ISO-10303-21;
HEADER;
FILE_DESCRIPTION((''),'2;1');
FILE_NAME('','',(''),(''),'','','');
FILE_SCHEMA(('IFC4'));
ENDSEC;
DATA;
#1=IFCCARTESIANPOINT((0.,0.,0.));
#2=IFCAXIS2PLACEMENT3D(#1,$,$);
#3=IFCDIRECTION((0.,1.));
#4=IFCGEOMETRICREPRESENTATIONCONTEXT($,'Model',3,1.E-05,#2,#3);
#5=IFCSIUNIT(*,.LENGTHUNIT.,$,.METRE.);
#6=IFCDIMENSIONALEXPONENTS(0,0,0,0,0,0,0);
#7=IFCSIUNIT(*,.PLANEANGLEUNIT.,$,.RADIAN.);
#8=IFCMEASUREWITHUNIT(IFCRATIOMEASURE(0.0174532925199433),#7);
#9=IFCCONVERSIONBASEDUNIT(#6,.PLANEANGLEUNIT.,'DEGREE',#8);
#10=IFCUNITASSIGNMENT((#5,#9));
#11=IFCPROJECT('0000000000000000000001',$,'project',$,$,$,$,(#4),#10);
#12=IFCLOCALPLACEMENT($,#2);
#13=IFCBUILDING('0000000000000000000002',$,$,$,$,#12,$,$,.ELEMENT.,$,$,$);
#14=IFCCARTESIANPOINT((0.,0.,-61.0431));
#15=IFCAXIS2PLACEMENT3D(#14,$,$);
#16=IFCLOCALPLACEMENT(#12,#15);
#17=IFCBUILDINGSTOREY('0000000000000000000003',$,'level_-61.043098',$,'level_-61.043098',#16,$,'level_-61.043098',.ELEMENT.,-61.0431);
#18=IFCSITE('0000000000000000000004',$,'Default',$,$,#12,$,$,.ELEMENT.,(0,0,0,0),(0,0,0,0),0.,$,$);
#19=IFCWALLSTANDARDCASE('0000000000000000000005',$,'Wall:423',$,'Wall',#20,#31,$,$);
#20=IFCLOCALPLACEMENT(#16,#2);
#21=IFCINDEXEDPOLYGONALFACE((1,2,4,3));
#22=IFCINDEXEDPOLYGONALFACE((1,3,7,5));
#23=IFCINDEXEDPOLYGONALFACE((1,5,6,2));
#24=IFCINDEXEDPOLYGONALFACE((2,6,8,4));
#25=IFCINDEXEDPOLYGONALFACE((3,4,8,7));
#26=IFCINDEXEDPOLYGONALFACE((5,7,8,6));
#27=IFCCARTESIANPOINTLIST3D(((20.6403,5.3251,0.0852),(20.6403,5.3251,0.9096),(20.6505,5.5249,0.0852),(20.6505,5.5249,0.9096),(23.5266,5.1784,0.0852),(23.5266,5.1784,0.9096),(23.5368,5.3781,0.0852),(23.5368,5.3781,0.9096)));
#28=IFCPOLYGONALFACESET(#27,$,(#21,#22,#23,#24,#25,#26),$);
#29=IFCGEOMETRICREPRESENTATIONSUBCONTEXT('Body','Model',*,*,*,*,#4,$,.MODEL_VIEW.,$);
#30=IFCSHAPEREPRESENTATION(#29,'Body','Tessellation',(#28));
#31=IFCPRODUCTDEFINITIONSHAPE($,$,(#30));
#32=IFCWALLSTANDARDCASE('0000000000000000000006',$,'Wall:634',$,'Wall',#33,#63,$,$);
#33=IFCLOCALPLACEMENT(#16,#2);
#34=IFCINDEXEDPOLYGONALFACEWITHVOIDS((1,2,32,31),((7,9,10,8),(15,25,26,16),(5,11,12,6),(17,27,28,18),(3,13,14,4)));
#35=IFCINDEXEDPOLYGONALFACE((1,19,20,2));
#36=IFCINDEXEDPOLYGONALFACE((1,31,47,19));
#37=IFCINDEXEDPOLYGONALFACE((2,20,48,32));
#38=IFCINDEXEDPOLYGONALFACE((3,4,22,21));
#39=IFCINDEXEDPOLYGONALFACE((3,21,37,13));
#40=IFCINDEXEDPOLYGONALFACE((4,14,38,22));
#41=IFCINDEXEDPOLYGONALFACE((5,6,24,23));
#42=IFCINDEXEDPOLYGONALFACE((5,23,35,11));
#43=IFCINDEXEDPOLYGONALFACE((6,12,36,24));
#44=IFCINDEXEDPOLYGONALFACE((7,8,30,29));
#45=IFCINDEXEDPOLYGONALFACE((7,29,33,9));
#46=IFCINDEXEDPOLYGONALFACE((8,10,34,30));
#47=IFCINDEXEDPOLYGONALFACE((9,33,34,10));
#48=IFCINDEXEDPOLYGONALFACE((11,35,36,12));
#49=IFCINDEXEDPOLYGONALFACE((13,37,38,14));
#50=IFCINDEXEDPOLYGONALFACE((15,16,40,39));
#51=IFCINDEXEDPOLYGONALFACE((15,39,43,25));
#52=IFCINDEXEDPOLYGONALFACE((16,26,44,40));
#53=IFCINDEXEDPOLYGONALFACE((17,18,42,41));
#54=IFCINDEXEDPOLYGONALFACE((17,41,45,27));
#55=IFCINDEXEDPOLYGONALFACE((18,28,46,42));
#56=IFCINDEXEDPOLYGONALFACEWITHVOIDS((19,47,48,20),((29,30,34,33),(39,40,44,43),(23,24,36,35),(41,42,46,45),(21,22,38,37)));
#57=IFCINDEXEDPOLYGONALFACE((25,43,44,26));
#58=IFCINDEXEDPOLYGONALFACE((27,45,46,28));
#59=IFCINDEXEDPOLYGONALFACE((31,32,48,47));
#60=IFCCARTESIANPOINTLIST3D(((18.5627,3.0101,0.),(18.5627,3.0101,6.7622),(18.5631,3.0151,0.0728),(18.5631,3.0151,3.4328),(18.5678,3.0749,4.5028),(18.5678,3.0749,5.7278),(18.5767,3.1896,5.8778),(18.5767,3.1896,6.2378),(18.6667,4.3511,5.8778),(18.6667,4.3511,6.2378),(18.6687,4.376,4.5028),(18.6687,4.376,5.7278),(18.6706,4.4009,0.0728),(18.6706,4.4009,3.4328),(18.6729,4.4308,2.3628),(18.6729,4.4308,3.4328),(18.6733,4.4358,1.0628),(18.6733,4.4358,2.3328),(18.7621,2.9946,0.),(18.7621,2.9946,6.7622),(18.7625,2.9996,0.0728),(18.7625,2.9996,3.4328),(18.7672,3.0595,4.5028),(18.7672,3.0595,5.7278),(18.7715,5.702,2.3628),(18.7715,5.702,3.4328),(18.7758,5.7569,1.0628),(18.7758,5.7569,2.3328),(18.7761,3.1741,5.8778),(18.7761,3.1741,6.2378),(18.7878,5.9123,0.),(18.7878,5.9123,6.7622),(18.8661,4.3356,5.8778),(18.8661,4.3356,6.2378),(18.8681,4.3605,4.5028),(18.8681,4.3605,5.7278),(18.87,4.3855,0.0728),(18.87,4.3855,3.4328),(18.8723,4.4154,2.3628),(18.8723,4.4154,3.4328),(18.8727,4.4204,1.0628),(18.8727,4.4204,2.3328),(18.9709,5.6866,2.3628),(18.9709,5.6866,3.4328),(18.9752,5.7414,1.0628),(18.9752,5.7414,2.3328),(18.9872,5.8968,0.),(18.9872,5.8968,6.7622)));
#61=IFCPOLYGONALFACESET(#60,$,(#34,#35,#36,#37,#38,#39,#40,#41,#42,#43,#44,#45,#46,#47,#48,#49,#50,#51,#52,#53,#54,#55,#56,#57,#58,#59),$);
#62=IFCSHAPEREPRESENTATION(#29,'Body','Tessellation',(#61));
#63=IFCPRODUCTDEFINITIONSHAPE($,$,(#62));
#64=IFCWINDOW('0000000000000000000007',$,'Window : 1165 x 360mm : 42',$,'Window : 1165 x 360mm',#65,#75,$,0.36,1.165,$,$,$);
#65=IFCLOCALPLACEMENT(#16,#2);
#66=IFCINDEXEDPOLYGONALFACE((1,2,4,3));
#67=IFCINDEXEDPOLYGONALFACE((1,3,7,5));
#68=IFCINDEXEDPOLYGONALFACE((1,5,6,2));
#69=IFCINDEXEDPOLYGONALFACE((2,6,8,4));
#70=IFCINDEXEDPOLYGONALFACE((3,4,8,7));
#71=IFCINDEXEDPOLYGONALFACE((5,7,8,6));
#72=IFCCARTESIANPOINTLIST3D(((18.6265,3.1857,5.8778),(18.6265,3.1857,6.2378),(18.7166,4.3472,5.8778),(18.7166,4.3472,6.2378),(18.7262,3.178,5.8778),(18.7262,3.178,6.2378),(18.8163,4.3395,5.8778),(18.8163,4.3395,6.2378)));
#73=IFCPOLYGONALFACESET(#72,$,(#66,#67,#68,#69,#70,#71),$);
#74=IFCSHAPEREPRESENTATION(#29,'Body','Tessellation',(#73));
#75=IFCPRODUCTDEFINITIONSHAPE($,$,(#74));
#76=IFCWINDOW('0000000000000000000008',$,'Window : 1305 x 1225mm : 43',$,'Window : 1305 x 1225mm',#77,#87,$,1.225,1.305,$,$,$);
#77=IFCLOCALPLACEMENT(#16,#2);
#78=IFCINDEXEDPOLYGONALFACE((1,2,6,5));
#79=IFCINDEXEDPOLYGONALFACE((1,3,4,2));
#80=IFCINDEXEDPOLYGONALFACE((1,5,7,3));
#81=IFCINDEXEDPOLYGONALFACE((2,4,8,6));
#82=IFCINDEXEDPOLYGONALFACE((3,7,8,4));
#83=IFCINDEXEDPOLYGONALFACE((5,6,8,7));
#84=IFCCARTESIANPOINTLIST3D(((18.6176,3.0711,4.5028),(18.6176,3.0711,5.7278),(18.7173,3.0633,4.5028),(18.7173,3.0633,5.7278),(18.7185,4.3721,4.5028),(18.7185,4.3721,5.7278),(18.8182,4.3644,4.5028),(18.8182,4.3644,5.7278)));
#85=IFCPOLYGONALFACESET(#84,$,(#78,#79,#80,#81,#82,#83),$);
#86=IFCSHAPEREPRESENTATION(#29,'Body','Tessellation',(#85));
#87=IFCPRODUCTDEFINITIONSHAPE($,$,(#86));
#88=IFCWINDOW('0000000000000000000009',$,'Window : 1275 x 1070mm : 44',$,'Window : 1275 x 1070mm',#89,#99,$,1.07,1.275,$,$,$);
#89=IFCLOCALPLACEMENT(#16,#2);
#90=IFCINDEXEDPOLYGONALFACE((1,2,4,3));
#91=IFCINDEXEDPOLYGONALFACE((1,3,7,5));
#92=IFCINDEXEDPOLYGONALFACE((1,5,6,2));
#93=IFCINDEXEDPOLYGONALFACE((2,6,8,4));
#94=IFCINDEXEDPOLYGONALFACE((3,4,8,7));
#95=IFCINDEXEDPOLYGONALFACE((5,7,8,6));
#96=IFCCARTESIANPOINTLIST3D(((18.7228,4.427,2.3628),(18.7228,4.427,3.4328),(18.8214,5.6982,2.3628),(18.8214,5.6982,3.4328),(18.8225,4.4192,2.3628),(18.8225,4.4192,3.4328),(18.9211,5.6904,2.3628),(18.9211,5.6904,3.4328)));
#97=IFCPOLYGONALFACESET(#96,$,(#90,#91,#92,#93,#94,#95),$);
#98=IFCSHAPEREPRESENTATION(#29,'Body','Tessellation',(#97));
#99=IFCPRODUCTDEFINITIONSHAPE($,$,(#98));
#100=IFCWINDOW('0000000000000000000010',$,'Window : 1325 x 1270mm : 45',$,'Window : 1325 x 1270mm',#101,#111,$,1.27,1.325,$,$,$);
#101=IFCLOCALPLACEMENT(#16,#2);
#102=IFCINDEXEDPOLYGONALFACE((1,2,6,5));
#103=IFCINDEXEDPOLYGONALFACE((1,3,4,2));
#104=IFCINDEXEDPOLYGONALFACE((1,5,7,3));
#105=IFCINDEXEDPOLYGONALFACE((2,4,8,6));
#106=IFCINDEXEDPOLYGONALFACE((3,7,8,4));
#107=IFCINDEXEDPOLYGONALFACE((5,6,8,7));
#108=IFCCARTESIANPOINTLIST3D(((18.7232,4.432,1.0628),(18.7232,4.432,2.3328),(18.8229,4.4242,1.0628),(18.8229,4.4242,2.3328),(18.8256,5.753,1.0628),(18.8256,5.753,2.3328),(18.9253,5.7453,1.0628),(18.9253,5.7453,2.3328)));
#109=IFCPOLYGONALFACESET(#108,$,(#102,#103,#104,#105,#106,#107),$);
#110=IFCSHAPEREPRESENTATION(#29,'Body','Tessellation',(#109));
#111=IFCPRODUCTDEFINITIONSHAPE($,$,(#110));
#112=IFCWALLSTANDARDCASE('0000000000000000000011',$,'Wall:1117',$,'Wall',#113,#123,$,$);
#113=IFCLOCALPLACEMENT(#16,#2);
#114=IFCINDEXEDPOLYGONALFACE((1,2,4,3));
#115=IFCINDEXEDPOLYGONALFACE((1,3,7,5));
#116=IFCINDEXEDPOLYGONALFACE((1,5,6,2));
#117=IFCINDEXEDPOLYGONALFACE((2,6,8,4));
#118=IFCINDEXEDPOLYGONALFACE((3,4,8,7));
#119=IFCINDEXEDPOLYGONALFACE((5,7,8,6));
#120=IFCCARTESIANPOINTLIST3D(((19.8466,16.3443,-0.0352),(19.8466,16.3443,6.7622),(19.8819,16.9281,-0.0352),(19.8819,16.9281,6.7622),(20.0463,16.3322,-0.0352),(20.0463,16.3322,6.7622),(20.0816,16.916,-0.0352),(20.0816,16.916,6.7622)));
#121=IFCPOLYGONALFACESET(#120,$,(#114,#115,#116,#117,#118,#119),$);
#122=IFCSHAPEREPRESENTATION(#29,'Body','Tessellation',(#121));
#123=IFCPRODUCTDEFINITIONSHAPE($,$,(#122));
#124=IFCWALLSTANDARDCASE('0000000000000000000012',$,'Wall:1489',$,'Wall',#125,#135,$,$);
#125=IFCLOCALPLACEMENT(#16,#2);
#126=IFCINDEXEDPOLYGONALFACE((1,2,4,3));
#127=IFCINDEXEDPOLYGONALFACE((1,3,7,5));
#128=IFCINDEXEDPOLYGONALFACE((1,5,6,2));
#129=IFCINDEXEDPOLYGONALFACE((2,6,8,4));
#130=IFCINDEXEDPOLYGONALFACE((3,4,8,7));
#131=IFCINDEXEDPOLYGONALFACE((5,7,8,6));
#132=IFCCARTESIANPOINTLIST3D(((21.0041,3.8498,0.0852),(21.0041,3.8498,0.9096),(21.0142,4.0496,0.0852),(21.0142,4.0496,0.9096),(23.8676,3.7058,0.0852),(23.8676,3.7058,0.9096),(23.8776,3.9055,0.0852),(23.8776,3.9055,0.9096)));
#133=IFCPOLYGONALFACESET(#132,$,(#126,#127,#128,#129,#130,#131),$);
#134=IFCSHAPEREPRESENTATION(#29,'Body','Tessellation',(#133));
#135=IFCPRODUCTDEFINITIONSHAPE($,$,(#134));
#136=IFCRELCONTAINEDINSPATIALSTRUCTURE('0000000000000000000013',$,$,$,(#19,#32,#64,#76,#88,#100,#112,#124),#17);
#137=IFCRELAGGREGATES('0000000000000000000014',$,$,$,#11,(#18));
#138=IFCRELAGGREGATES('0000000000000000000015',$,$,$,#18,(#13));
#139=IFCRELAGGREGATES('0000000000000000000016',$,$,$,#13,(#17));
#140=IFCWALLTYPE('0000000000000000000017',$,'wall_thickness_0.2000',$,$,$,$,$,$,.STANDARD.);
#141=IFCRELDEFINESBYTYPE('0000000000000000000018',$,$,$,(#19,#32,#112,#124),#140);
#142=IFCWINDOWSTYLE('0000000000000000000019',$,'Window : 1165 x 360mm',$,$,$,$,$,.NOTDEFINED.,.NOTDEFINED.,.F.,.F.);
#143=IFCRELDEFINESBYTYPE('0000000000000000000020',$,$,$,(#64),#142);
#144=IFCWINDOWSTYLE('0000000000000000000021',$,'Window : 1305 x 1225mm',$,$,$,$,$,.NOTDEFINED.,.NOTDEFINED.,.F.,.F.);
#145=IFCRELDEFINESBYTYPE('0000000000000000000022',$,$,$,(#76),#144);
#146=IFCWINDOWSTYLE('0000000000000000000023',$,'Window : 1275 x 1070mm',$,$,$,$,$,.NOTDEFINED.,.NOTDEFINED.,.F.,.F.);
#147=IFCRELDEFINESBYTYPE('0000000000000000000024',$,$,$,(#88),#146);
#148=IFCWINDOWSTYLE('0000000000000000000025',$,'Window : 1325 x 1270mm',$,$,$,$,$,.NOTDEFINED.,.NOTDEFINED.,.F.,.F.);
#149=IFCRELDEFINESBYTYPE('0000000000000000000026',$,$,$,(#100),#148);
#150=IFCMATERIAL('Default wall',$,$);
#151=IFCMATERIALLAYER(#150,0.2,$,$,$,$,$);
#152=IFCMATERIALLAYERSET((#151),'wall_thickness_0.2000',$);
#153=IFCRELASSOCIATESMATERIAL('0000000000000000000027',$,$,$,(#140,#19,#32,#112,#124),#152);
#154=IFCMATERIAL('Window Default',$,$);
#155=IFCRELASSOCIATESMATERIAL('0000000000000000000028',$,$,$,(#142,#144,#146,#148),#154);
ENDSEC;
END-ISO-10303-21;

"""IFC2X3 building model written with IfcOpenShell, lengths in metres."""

from ifc_helpers import new_model, entity, si_unit, converted_unit, direction, frame, frame_2d, origin, origin_2d_with_axis, place, context, subcontext, project, spatial, polyline, rectangle, outline, extrude, source, transform, mapped, material, layer, layer_set, layer_usage, type_object, type_shapes, element, fill, save


model = new_model("IFC2X3")

# Units and contexts
model_context = context("Model", 3, precision=1e-05, world=origin(), true_north=direction((0.0, 1.0)))
body_context = subcontext(model_context, "Body", "Model", "MODEL_VIEW")
ifc_project = project(units=[si_unit("LENGTHUNIT", "METRE"), converted_unit("PLANEANGLEUNIT", "DEGREE", entity("IfcRatioMeasure", 0.0174532925199433), si_unit("PLANEANGLEUNIT", "RADIAN"), dimensions=[0, 0, 0, 0, 0, 0, 0])], contexts=[model_context])

# Site, building, storey
placement_1 = place(None, origin())
site = spatial("IfcSite", under=ifc_project, at=placement_1, Name="Default", CompositionType="ELEMENT", RefLatitude=(0, 0, 0, 0), RefLongitude=(0, 0, 0, 0), RefElevation=0.0)
building = spatial("IfcBuilding", under=site, at=placement_1, CompositionType="ELEMENT")
storey_placement = place(placement_1, frame((0.0, 0.0, -61.0431)))
storey = spatial("IfcBuildingStorey", under=building, at=storey_placement, Name="level_-61.043098", ObjectType="level_-61.043098", LongName="level_-61.043098", CompositionType="ELEMENT", Elevation=-61.0431)

# Shared definitions
ifc_material_1 = material(Name="Default wall")
ifc_layer = layer(ifc_material_1, 0.2)
ifc_layer_set = layer_set([ifc_layer], Name="wall_thickness_0.2000")
ifc_layer_usage = layer_usage(ifc_layer_set, "AXIS2", "POSITIVE", -0.1)
wall_type = type_object("IfcWallType", Name="wall_thickness_0.2000", PredefinedType="STANDARD", material=ifc_layer_set)
ifc_material_2 = material(Name="Window Default")

# Wall
placement_2 = place(placement_1, frame((0.0, 0.0, -60.9579)))
wall_1_placement = place(placement_2, frame((20.6454, 5.425, 0.0), z_axis=(0.0, 0.0, 1.0), x_axis=(0.998711, -0.050764, 0.0)))
element("IfcWallStandardCase", 1, at=wall_1_placement, inside=storey, type_object=wall_type, material=ifc_layer_usage, Name="Wall:423", ObjectType="Wall", context=body_context, shape_type="SweptSolid", body=[
    extrude(outline(polyline([(2.89, -0.1), (2.89, 0.1), (0.0, 0.1), (0.0, -0.1), (2.89, -0.1)])), origin(), (0.0, 0.0, 1.0), 0.8244),
])

# Wall, openings, windows
wall_2_placement = place(storey_placement, frame((18.8875, 5.9046, 0.0), z_axis=(0.0, 0.0, 1.0), x_axis=(-0.077332, -0.997005, 0.0)))
wall_2 = element("IfcWallStandardCase", 2, at=wall_2_placement, inside=storey, type_object=wall_type, material=ifc_layer_usage, Name="Wall:634", ObjectType="Wall", context=body_context, shape_type="SweptSolid", body=[
    extrude(outline(polyline([(2.9109, -0.1), (2.9109, 0.1), (0.0, 0.1), (0.0, -0.1), (2.9109, -0.1)])), origin(), (0.0, 0.0, 1.0), 6.7622),
])
opening_1_placement = place(wall_2_placement, frame((1.5159, -0.1, 0.0728)))
element("IfcOpeningElement", 3, at=opening_1_placement, cuts=wall_2, ObjectType="Opening", context=body_context, shape_type="SweptSolid", body=[
    extrude(rectangle(XDim=1.39, YDim=3.36, at=frame_2d((1.68, 0.695), x_axis=(0.0, 1.0))), frame((0.0, 0.0, 0.0), z_axis=(0.0, 1.0, 0.0), x_axis=(0.0, 0.0, 1.0)), (0.0, 0.0, 1.0), 0.2),
])
opening_2_placement = place(wall_2_placement, frame((1.5659, -0.1, 5.8778)))
opening_2 = element("IfcOpeningElement", 4, at=opening_2_placement, cuts=wall_2, ObjectType="Opening", context=body_context, shape_type="SweptSolid", body=[
    extrude(rectangle(XDim=1.165, YDim=0.36, at=frame_2d((0.18, 0.5825), x_axis=(0.0, 1.0))), frame((0.0, 0.0, 0.0), z_axis=(0.0, 1.0, 0.0), x_axis=(0.0, 0.0, 1.0)), (0.0, 0.0, 1.0), 0.2),
])
opening_3_placement = place(wall_2_placement, frame((1.5409, -0.1, 4.5028)))
opening_3 = element("IfcOpeningElement", 5, at=opening_3_placement, cuts=wall_2, ObjectType="Opening", context=body_context, shape_type="SweptSolid", body=[
    extrude(rectangle(XDim=1.305, YDim=1.225, at=frame_2d((0.6125, 0.6525), x_axis=(0.0, 1.0))), frame((0.0, 0.0, 0.0), z_axis=(0.0, 1.0, 0.0), x_axis=(0.0, 0.0, 1.0)), (0.0, 0.0, 1.0), 0.2),
])
opening_4_placement = place(wall_2_placement, frame((0.2109, -0.1, 2.3628)))
opening_4 = element("IfcOpeningElement", 6, at=opening_4_placement, cuts=wall_2, ObjectType="Opening", context=body_context, shape_type="SweptSolid", body=[
    extrude(rectangle(XDim=1.275, YDim=1.07, at=frame_2d((0.535, 0.6375), x_axis=(0.0, 1.0))), frame((0.0, 0.0, 0.0), z_axis=(0.0, 1.0, 0.0), x_axis=(0.0, 0.0, 1.0)), (0.0, 0.0, 1.0), 0.2),
])
opening_5_placement = place(wall_2_placement, frame((0.1559, -0.1, 1.0628)))
opening_5 = element("IfcOpeningElement", 7, at=opening_5_placement, cuts=wall_2, ObjectType="Opening", context=body_context, shape_type="SweptSolid", body=[
    extrude(rectangle(XDim=1.325, YDim=1.27, at=frame_2d((0.635, 0.6625), x_axis=(0.0, 1.0))), frame((0.0, 0.0, 0.0), z_axis=(0.0, 1.0, 0.0), x_axis=(0.0, 0.0, 1.0)), (0.0, 0.0, 1.0), 0.2),
])
window_style_1 = type_object("IfcWindowStyle", Name="Window : 1165 x 360mm", ConstructionType="NOTDEFINED", OperationType="NOTDEFINED", ParameterTakesPrecedence=False, Sizeable=False, material=ifc_material_2)
shared_shape_1 = source(origin(), body_context, "Body", "SweptSolid", [
    extrude(rectangle(XDim=0.1, YDim=1.165, at=origin_2d_with_axis()), frame((0.5825, 0.1, 0.0), z_axis=(0.0, 0.0, 1.0), x_axis=(0.0, 1.0, 0.0)), (0.0, 0.0, 1.0), 0.36),
])
type_shapes(window_style_1, [shared_shape_1])
window_1_placement = place(opening_2_placement, origin())
window_1 = element("IfcWindow", 8, at=window_1_placement, inside=storey, type_object=window_style_1, Name="Window : 1165 x 360mm : 42", ObjectType="Window : 1165 x 360mm", OverallHeight=0.36, OverallWidth=1.165, context=body_context, shape_type="MappedRepresentation", body=[
    mapped(shared_shape_1, transform((0.0, 0.0, 0.0), scale=1.0)),
])
fill(opening_2, window_1)
window_style_2 = type_object("IfcWindowStyle", Name="Window : 1305 x 1225mm", ConstructionType="NOTDEFINED", OperationType="NOTDEFINED", ParameterTakesPrecedence=False, Sizeable=False, material=ifc_material_2)
shared_shape_2 = source(origin(), body_context, "Body", "SweptSolid", [
    extrude(rectangle(XDim=0.1, YDim=1.305, at=origin_2d_with_axis()), frame((0.6525, 0.1, 0.0), z_axis=(0.0, 0.0, 1.0), x_axis=(0.0, 1.0, 0.0)), (0.0, 0.0, 1.0), 1.225),
])
type_shapes(window_style_2, [shared_shape_2])
window_2_placement = place(opening_3_placement, origin())
window_2 = element("IfcWindow", 9, at=window_2_placement, inside=storey, type_object=window_style_2, Name="Window : 1305 x 1225mm : 43", ObjectType="Window : 1305 x 1225mm", OverallHeight=1.225, OverallWidth=1.305, context=body_context, shape_type="MappedRepresentation", body=[
    mapped(shared_shape_2, transform((0.0, 0.0, 0.0), scale=1.0)),
])
fill(opening_3, window_2)
window_style_3 = type_object("IfcWindowStyle", Name="Window : 1275 x 1070mm", ConstructionType="NOTDEFINED", OperationType="NOTDEFINED", ParameterTakesPrecedence=False, Sizeable=False, material=ifc_material_2)
shared_shape_3 = source(origin(), body_context, "Body", "SweptSolid", [
    extrude(rectangle(XDim=0.1, YDim=1.275, at=origin_2d_with_axis()), frame((0.6375, 0.1, 0.0), z_axis=(0.0, 0.0, 1.0), x_axis=(0.0, 1.0, 0.0)), (0.0, 0.0, 1.0), 1.07),
])
type_shapes(window_style_3, [shared_shape_3])
window_3_placement = place(opening_4_placement, origin())
window_3 = element("IfcWindow", 10, at=window_3_placement, inside=storey, type_object=window_style_3, Name="Window : 1275 x 1070mm : 44", ObjectType="Window : 1275 x 1070mm", OverallHeight=1.07, OverallWidth=1.275, context=body_context, shape_type="MappedRepresentation", body=[
    mapped(shared_shape_3, transform((0.0, 0.0, 0.0), scale=1.0)),
])
fill(opening_4, window_3)
window_style_4 = type_object("IfcWindowStyle", Name="Window : 1325 x 1270mm", ConstructionType="NOTDEFINED", OperationType="NOTDEFINED", ParameterTakesPrecedence=False, Sizeable=False, material=ifc_material_2)
shared_shape_4 = source(origin(), body_context, "Body", "SweptSolid", [
    extrude(rectangle(XDim=0.1, YDim=1.325, at=origin_2d_with_axis()), frame((0.6625, 0.1, 0.0), z_axis=(0.0, 0.0, 1.0), x_axis=(0.0, 1.0, 0.0)), (0.0, 0.0, 1.0), 1.27),
])
type_shapes(window_style_4, [shared_shape_4])
window_4_placement = place(opening_5_placement, origin())
window_4 = element("IfcWindow", 11, at=window_4_placement, inside=storey, type_object=window_style_4, Name="Window : 1325 x 1270mm : 45", ObjectType="Window : 1325 x 1270mm", OverallHeight=1.27, OverallWidth=1.325, context=body_context, shape_type="MappedRepresentation", body=[
    mapped(shared_shape_4, transform((0.0, 0.0, 0.0), scale=1.0)),
])
fill(opening_5, window_4)

# Walls
placement_3 = place(placement_1, frame((0.0, 0.0, -61.0783)))
wall_3_placement = place(placement_3, frame((19.9818, 16.9221, 0.0), z_axis=(0.0, 0.0, 1.0), x_axis=(-0.060352, -0.998177, 0.0)))
element("IfcWallStandardCase", 12, at=wall_3_placement, inside=storey, type_object=wall_type, material=ifc_layer_usage, Name="Wall:1117", ObjectType="Wall", context=body_context, shape_type="SweptSolid", body=[
    extrude(outline(polyline([(0.5849, -0.1), (0.5849, 0.1), (0.0, 0.1), (0.0, -0.1), (0.5849, -0.1)])), origin(), (0.0, 0.0, 1.0), 6.7974),
])
placement_4 = place(placement_1, frame((0.0, 0.0, -60.9579)))
wall_4_placement = place(placement_4, frame((21.0091, 3.9497, 0.0), z_axis=(0.0, 0.0, 1.0), x_axis=(0.998737, -0.050239, 0.0)))
element("IfcWallStandardCase", 13, at=wall_4_placement, inside=storey, type_object=wall_type, material=ifc_layer_usage, Name="Wall:1489", ObjectType="Wall", context=body_context, shape_type="SweptSolid", body=[
    extrude(outline(polyline([(2.8671, -0.1), (2.8671, 0.1), (0.0, 0.1), (0.0, -0.1), (2.8671, -0.1)])), origin(), (0.0, 0.0, 1.0), 0.8244),
])

save(model, "model.ifc")
